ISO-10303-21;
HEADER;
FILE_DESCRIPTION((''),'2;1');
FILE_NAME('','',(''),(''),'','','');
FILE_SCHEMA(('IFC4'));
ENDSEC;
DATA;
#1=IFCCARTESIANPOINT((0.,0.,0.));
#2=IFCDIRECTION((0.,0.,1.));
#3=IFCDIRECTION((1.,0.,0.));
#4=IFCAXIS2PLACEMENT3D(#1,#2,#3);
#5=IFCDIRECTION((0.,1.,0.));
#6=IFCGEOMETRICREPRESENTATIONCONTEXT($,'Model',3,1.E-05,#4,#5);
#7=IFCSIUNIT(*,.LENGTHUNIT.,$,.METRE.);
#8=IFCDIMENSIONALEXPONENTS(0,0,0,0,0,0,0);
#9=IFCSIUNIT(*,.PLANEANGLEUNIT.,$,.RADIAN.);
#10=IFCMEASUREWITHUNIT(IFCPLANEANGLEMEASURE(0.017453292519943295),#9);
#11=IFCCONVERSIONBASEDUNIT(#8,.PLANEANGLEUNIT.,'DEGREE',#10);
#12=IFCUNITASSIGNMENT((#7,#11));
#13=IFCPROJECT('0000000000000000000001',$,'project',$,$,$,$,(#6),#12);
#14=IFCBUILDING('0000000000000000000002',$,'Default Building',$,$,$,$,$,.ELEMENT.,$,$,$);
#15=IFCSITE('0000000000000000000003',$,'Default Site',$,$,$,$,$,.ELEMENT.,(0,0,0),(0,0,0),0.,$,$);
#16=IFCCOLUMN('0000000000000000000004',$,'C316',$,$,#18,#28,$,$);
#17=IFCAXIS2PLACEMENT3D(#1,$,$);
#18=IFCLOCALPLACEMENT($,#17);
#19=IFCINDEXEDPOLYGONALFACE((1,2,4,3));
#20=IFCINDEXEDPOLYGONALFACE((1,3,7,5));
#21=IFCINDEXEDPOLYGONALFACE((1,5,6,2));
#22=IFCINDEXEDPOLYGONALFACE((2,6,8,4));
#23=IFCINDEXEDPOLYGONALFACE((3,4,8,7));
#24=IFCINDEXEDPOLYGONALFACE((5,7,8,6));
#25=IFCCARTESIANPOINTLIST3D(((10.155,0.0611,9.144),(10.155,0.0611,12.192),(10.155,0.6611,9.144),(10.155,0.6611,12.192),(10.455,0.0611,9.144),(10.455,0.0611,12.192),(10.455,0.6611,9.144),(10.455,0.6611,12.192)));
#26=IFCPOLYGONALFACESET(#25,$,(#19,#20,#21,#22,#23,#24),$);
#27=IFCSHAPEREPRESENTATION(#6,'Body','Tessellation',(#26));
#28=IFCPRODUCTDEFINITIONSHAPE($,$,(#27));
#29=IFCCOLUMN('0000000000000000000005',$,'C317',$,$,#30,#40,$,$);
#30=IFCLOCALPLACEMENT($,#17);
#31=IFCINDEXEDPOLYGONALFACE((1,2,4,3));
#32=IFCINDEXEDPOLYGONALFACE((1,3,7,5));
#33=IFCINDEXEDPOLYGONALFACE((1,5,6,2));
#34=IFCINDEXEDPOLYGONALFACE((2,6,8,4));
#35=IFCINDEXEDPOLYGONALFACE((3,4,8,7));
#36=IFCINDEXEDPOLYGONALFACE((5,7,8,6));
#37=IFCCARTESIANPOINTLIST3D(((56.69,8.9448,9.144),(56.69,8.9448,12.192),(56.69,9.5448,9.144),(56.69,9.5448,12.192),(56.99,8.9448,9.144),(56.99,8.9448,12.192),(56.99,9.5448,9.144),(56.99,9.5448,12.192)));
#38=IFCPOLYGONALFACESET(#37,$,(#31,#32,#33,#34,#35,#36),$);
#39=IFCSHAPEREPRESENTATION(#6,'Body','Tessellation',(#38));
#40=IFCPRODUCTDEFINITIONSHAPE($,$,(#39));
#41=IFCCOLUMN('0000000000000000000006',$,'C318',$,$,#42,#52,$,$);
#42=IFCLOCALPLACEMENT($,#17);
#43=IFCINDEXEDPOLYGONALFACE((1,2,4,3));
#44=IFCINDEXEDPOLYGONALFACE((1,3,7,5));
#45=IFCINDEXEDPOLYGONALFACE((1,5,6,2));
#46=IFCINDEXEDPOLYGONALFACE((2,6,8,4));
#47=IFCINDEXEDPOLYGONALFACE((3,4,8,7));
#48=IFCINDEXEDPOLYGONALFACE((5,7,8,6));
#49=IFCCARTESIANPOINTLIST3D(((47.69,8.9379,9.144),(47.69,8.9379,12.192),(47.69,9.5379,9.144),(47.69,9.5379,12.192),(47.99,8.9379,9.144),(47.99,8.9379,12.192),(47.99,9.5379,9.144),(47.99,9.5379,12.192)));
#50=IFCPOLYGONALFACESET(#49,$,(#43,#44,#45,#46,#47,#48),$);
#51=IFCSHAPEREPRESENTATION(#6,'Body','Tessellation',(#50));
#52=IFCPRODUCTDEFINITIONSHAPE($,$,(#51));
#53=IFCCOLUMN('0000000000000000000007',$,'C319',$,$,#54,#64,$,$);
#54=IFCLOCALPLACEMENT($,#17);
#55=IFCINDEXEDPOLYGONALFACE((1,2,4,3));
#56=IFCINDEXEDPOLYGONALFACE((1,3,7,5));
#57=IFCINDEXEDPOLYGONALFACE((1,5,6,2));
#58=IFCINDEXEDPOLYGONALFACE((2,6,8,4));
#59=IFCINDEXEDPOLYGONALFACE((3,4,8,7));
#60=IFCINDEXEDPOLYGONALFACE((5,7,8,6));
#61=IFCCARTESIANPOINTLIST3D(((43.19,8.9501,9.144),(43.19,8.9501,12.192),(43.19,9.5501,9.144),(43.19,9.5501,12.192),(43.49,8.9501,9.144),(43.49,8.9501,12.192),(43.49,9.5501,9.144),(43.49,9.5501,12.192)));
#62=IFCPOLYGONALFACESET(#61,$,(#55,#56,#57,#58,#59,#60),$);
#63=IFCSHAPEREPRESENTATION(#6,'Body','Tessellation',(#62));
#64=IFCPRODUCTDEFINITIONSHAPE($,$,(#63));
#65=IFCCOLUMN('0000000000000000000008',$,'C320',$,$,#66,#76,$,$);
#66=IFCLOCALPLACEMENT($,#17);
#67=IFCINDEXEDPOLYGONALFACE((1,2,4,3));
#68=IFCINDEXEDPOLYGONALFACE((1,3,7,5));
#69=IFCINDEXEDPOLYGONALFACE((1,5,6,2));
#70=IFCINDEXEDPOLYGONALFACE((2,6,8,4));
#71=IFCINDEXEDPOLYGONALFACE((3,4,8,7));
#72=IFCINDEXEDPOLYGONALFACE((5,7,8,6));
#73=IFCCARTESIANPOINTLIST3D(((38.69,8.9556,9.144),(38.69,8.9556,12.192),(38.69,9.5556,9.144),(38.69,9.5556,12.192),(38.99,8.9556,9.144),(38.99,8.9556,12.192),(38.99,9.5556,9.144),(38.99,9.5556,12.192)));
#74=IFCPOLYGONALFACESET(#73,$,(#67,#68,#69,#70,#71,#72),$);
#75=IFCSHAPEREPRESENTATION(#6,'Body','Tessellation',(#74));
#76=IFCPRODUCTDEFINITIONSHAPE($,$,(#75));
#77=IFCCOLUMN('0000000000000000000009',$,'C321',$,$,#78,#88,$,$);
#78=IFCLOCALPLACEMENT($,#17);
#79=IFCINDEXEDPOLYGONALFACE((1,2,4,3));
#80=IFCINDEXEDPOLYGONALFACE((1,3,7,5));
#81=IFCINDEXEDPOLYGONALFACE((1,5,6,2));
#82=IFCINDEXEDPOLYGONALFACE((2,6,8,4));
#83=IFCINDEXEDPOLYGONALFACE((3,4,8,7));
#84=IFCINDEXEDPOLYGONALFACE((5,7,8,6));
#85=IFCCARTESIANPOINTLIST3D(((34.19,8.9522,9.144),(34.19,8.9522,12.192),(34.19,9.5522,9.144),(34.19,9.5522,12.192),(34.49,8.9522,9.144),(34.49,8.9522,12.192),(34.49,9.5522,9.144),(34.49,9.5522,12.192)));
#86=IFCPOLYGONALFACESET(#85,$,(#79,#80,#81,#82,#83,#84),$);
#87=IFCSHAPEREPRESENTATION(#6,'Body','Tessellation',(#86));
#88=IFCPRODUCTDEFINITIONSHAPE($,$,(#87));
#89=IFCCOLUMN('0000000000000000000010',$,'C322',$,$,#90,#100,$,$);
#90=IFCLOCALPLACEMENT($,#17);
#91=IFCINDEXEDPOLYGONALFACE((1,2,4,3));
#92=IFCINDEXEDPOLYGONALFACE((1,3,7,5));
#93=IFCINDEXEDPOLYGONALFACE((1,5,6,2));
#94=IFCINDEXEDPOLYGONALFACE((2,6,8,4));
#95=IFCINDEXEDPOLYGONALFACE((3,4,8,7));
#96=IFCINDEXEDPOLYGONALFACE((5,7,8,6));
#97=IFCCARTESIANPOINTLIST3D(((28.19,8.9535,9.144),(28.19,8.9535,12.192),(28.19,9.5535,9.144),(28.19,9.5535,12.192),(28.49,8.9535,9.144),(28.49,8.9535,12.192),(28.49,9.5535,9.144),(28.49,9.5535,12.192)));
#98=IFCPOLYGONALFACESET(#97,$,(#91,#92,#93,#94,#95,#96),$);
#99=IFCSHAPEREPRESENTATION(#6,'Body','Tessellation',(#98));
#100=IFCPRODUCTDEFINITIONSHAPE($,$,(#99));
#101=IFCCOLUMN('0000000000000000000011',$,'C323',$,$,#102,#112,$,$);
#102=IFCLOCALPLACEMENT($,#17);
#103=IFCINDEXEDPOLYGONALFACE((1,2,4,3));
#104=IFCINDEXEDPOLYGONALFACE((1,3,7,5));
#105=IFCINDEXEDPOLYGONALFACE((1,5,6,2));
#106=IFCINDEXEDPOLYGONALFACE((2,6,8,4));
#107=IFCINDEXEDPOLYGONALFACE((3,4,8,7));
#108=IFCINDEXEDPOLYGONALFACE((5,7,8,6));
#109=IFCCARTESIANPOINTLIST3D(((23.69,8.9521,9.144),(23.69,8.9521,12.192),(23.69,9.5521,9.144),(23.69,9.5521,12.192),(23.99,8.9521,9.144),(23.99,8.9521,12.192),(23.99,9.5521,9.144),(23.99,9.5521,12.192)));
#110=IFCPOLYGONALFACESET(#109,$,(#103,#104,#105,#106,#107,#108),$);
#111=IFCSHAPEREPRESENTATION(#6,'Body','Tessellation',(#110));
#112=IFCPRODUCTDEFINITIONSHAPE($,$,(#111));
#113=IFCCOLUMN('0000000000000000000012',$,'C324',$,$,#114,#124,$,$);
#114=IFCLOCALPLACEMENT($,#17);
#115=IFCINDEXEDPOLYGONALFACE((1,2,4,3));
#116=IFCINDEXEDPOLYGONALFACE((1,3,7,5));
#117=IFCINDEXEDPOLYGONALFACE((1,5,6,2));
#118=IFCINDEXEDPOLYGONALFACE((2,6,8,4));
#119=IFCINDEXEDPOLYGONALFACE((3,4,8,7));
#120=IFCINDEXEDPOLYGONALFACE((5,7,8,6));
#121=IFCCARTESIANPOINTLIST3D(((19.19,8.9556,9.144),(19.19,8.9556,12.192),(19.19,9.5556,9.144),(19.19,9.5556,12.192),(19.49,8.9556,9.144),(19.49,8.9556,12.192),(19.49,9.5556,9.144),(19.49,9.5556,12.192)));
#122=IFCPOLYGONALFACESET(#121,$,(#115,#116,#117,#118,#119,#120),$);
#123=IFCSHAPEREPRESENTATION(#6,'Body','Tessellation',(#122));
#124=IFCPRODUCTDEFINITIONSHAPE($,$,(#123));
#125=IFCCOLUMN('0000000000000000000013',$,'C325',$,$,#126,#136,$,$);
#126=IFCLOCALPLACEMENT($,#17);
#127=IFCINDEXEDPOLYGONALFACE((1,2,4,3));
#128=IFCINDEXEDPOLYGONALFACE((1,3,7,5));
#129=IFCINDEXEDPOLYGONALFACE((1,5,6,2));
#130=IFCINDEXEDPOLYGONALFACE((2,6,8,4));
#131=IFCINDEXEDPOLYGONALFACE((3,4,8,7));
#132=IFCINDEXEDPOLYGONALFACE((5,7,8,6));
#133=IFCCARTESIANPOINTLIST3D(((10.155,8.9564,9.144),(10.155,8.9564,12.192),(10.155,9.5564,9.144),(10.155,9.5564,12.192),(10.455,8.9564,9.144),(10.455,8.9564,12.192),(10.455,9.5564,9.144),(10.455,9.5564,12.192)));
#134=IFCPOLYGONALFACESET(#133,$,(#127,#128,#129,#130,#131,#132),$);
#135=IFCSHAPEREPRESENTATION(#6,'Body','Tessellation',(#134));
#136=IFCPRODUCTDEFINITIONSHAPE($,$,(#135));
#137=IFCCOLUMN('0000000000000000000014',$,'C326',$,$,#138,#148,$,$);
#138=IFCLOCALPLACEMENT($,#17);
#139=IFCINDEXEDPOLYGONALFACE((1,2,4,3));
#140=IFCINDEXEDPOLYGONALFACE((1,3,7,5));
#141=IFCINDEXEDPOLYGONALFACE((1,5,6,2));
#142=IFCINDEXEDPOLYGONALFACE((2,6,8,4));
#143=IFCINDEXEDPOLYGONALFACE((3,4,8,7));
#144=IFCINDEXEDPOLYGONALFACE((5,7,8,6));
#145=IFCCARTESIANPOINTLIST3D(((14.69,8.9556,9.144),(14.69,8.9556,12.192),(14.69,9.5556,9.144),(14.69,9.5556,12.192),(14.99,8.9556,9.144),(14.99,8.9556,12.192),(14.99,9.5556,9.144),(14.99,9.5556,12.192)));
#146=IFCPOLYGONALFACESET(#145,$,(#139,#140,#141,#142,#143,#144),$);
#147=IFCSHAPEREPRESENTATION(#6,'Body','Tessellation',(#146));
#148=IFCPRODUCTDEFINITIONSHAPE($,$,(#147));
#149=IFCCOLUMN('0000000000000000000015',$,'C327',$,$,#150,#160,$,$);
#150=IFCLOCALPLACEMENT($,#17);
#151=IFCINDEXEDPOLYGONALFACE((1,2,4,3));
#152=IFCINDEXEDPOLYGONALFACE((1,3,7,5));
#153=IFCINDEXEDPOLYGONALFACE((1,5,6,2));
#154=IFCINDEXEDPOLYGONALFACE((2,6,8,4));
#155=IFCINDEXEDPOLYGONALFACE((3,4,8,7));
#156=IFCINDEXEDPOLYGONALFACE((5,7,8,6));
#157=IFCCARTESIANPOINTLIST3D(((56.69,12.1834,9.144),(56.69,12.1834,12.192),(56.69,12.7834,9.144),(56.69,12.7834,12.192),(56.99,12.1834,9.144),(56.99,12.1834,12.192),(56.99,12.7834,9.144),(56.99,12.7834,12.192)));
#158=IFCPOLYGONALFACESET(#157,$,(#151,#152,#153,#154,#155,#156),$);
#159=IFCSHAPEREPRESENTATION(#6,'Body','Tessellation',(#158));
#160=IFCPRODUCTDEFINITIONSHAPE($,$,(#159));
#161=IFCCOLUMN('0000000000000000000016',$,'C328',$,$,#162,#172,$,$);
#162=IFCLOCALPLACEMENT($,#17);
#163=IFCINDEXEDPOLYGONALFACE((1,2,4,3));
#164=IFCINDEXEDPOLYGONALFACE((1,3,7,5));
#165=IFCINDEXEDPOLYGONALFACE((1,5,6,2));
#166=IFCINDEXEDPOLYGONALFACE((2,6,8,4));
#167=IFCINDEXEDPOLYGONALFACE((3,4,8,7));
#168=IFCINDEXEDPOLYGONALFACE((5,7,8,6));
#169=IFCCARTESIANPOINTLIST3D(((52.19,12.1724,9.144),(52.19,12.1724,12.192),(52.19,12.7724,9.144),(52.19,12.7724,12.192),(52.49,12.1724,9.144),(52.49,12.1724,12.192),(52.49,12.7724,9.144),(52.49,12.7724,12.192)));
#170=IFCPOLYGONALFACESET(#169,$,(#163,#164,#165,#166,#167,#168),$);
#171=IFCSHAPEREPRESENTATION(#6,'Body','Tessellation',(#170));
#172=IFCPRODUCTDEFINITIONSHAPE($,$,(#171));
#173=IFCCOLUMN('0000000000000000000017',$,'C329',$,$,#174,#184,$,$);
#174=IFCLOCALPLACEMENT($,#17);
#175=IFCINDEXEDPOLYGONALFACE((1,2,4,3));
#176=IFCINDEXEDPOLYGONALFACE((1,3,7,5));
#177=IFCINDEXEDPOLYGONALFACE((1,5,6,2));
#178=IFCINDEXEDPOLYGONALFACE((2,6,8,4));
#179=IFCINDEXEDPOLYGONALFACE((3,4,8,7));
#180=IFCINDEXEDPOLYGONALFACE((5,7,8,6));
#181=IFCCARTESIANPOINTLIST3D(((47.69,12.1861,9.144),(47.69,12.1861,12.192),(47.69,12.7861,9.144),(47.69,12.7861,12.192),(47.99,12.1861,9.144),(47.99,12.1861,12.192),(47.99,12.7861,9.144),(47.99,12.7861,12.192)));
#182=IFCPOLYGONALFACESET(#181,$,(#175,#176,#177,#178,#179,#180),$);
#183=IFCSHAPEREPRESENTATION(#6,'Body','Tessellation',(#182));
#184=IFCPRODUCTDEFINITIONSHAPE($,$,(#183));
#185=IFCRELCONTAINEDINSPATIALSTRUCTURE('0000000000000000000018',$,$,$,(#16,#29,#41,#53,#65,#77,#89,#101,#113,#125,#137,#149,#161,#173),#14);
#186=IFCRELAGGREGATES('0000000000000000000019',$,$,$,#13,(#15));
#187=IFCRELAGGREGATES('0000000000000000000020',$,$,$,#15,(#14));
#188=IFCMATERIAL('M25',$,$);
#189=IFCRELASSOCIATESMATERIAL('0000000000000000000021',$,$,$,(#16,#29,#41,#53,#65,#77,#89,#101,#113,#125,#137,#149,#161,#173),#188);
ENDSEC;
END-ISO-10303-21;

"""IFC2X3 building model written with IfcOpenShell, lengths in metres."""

from ifc_helpers import new_model, entity, si_unit, converted_unit, direction, frame, frame_2d, origin_with_axes, place, context, project, spatial, rectangle, extrude, material, element, save


model = new_model("IFC2X3")

# Units and contexts
model_context = context("Model", 3, precision=1e-05, world=origin_with_axes(), true_north=direction((0.0, 1.0, 0.0)))
ifc_project = project(units=[si_unit("LENGTHUNIT", "METRE"), converted_unit("PLANEANGLEUNIT", "DEGREE", entity("IfcPlaneAngleMeasure", 0.017453292519943295), si_unit("PLANEANGLEUNIT", "RADIAN"), dimensions=[0, 0, 0, 0, 0, 0, 0])], contexts=[model_context])

# Site, building
site = spatial("IfcSite", under=ifc_project, Name="Default Site", CompositionType="ELEMENT", RefLatitude=(0, 0, 0), RefLongitude=(0, 0, 0), RefElevation=0.0)
building = spatial("IfcBuilding", under=site, Name="Default Building", CompositionType="ELEMENT")

# Columns
ifc_material = material(Name="M25")
placement = place(None, origin_with_axes())
element("IfcColumn", 1, at=placement, inside=building, material=ifc_material, Name="C316", context=model_context, shape_type="SweptSolid", body=[
    extrude(rectangle(XDim=0.3, YDim=0.6, at=frame_2d((0.0, 0.0), x_axis=(1.0, 0.0, 0.0))), frame((10.305, 0.3611, 9.144), z_axis=(0.0, 0.0, 1.0), x_axis=(1.0, 0.0, 0.0)), (0.0, 0.0, 1.0), 3.048),
])
element("IfcColumn", 2, at=placement, inside=building, material=ifc_material, Name="C317", context=model_context, shape_type="SweptSolid", body=[
    extrude(rectangle(XDim=0.3, YDim=0.6, at=frame_2d((0.0, 0.0), x_axis=(1.0, 0.0, 0.0))), frame((56.84, 9.2448, 9.144), z_axis=(0.0, 0.0, 1.0), x_axis=(1.0, 0.0, 0.0)), (0.0, 0.0, 1.0), 3.048),
])
element("IfcColumn", 3, at=placement, inside=building, material=ifc_material, Name="C318", context=model_context, shape_type="SweptSolid", body=[
    extrude(rectangle(XDim=0.3, YDim=0.6, at=frame_2d((0.0, 0.0), x_axis=(1.0, 0.0, 0.0))), frame((47.84, 9.2379, 9.144), z_axis=(0.0, 0.0, 1.0), x_axis=(1.0, 0.0, 0.0)), (0.0, 0.0, 1.0), 3.048),
])
element("IfcColumn", 4, at=placement, inside=building, material=ifc_material, Name="C319", context=model_context, shape_type="SweptSolid", body=[
    extrude(rectangle(XDim=0.3, YDim=0.6, at=frame_2d((0.0, 0.0), x_axis=(1.0, 0.0, 0.0))), frame((43.34, 9.2501, 9.144), z_axis=(0.0, 0.0, 1.0), x_axis=(1.0, 0.0, 0.0)), (0.0, 0.0, 1.0), 3.048),
])
element("IfcColumn", 5, at=placement, inside=building, material=ifc_material, Name="C320", context=model_context, shape_type="SweptSolid", body=[
    extrude(rectangle(XDim=0.3, YDim=0.6, at=frame_2d((0.0, 0.0), x_axis=(1.0, 0.0, 0.0))), frame((38.84, 9.2556, 9.144), z_axis=(0.0, 0.0, 1.0), x_axis=(1.0, 0.0, 0.0)), (0.0, 0.0, 1.0), 3.048),
])
element("IfcColumn", 6, at=placement, inside=building, material=ifc_material, Name="C321", context=model_context, shape_type="SweptSolid", body=[
    extrude(rectangle(XDim=0.3, YDim=0.6, at=frame_2d((0.0, 0.0), x_axis=(1.0, 0.0, 0.0))), frame((34.34, 9.2522, 9.144), z_axis=(0.0, 0.0, 1.0), x_axis=(1.0, 0.0, 0.0)), (0.0, 0.0, 1.0), 3.048),
])
element("IfcColumn", 7, at=placement, inside=building, material=ifc_material, Name="C322", context=model_context, shape_type="SweptSolid", body=[
    extrude(rectangle(XDim=0.3, YDim=0.6, at=frame_2d((0.0, 0.0), x_axis=(1.0, 0.0, 0.0))), frame((28.34, 9.2535, 9.144), z_axis=(0.0, 0.0, 1.0), x_axis=(1.0, 0.0, 0.0)), (0.0, 0.0, 1.0), 3.048),
])
element("IfcColumn", 8, at=placement, inside=building, material=ifc_material, Name="C323", context=model_context, shape_type="SweptSolid", body=[
    extrude(rectangle(XDim=0.3, YDim=0.6, at=frame_2d((0.0, 0.0), x_axis=(1.0, 0.0, 0.0))), frame((23.84, 9.2521, 9.144), z_axis=(0.0, 0.0, 1.0), x_axis=(1.0, 0.0, 0.0)), (0.0, 0.0, 1.0), 3.048),
])
element("IfcColumn", 9, at=placement, inside=building, material=ifc_material, Name="C324", context=model_context, shape_type="SweptSolid", body=[
    extrude(rectangle(XDim=0.3, YDim=0.6, at=frame_2d((0.0, 0.0), x_axis=(1.0, 0.0, 0.0))), frame((19.34, 9.2556, 9.144), z_axis=(0.0, 0.0, 1.0), x_axis=(1.0, 0.0, 0.0)), (0.0, 0.0, 1.0), 3.048),
])
element("IfcColumn", 10, at=placement, inside=building, material=ifc_material, Name="C325", context=model_context, shape_type="SweptSolid", body=[
    extrude(rectangle(XDim=0.3, YDim=0.6, at=frame_2d((0.0, 0.0), x_axis=(1.0, 0.0, 0.0))), frame((10.305, 9.2564, 9.144), z_axis=(0.0, 0.0, 1.0), x_axis=(1.0, 0.0, 0.0)), (0.0, 0.0, 1.0), 3.048),
])
element("IfcColumn", 11, at=placement, inside=building, material=ifc_material, Name="C326", context=model_context, shape_type="SweptSolid", body=[
    extrude(rectangle(XDim=0.3, YDim=0.6, at=frame_2d((0.0, 0.0), x_axis=(1.0, 0.0, 0.0))), frame((14.84, 9.2556, 9.144), z_axis=(0.0, 0.0, 1.0), x_axis=(1.0, 0.0, 0.0)), (0.0, 0.0, 1.0), 3.048),
])
element("IfcColumn", 12, at=placement, inside=building, material=ifc_material, Name="C327", context=model_context, shape_type="SweptSolid", body=[
    extrude(rectangle(XDim=0.3, YDim=0.6, at=frame_2d((0.0, 0.0), x_axis=(1.0, 0.0, 0.0))), frame((56.84, 12.4834, 9.144), z_axis=(0.0, 0.0, 1.0), x_axis=(1.0, 0.0, 0.0)), (0.0, 0.0, 1.0), 3.048),
])
element("IfcColumn", 13, at=placement, inside=building, material=ifc_material, Name="C328", context=model_context, shape_type="SweptSolid", body=[
    extrude(rectangle(XDim=0.3, YDim=0.6, at=frame_2d((0.0, 0.0), x_axis=(1.0, 0.0, 0.0))), frame((52.34, 12.4724, 9.144), z_axis=(0.0, 0.0, 1.0), x_axis=(1.0, 0.0, 0.0)), (0.0, 0.0, 1.0), 3.048),
])
element("IfcColumn", 14, at=placement, inside=building, material=ifc_material, Name="C329", context=model_context, shape_type="SweptSolid", body=[
    extrude(rectangle(XDim=0.3, YDim=0.6, at=frame_2d((0.0, 0.0), x_axis=(1.0, 0.0, 0.0))), frame((47.84, 12.4861, 9.144), z_axis=(0.0, 0.0, 1.0), x_axis=(1.0, 0.0, 0.0)), (0.0, 0.0, 1.0), 3.048),
])

save(model, "model.ifc")
